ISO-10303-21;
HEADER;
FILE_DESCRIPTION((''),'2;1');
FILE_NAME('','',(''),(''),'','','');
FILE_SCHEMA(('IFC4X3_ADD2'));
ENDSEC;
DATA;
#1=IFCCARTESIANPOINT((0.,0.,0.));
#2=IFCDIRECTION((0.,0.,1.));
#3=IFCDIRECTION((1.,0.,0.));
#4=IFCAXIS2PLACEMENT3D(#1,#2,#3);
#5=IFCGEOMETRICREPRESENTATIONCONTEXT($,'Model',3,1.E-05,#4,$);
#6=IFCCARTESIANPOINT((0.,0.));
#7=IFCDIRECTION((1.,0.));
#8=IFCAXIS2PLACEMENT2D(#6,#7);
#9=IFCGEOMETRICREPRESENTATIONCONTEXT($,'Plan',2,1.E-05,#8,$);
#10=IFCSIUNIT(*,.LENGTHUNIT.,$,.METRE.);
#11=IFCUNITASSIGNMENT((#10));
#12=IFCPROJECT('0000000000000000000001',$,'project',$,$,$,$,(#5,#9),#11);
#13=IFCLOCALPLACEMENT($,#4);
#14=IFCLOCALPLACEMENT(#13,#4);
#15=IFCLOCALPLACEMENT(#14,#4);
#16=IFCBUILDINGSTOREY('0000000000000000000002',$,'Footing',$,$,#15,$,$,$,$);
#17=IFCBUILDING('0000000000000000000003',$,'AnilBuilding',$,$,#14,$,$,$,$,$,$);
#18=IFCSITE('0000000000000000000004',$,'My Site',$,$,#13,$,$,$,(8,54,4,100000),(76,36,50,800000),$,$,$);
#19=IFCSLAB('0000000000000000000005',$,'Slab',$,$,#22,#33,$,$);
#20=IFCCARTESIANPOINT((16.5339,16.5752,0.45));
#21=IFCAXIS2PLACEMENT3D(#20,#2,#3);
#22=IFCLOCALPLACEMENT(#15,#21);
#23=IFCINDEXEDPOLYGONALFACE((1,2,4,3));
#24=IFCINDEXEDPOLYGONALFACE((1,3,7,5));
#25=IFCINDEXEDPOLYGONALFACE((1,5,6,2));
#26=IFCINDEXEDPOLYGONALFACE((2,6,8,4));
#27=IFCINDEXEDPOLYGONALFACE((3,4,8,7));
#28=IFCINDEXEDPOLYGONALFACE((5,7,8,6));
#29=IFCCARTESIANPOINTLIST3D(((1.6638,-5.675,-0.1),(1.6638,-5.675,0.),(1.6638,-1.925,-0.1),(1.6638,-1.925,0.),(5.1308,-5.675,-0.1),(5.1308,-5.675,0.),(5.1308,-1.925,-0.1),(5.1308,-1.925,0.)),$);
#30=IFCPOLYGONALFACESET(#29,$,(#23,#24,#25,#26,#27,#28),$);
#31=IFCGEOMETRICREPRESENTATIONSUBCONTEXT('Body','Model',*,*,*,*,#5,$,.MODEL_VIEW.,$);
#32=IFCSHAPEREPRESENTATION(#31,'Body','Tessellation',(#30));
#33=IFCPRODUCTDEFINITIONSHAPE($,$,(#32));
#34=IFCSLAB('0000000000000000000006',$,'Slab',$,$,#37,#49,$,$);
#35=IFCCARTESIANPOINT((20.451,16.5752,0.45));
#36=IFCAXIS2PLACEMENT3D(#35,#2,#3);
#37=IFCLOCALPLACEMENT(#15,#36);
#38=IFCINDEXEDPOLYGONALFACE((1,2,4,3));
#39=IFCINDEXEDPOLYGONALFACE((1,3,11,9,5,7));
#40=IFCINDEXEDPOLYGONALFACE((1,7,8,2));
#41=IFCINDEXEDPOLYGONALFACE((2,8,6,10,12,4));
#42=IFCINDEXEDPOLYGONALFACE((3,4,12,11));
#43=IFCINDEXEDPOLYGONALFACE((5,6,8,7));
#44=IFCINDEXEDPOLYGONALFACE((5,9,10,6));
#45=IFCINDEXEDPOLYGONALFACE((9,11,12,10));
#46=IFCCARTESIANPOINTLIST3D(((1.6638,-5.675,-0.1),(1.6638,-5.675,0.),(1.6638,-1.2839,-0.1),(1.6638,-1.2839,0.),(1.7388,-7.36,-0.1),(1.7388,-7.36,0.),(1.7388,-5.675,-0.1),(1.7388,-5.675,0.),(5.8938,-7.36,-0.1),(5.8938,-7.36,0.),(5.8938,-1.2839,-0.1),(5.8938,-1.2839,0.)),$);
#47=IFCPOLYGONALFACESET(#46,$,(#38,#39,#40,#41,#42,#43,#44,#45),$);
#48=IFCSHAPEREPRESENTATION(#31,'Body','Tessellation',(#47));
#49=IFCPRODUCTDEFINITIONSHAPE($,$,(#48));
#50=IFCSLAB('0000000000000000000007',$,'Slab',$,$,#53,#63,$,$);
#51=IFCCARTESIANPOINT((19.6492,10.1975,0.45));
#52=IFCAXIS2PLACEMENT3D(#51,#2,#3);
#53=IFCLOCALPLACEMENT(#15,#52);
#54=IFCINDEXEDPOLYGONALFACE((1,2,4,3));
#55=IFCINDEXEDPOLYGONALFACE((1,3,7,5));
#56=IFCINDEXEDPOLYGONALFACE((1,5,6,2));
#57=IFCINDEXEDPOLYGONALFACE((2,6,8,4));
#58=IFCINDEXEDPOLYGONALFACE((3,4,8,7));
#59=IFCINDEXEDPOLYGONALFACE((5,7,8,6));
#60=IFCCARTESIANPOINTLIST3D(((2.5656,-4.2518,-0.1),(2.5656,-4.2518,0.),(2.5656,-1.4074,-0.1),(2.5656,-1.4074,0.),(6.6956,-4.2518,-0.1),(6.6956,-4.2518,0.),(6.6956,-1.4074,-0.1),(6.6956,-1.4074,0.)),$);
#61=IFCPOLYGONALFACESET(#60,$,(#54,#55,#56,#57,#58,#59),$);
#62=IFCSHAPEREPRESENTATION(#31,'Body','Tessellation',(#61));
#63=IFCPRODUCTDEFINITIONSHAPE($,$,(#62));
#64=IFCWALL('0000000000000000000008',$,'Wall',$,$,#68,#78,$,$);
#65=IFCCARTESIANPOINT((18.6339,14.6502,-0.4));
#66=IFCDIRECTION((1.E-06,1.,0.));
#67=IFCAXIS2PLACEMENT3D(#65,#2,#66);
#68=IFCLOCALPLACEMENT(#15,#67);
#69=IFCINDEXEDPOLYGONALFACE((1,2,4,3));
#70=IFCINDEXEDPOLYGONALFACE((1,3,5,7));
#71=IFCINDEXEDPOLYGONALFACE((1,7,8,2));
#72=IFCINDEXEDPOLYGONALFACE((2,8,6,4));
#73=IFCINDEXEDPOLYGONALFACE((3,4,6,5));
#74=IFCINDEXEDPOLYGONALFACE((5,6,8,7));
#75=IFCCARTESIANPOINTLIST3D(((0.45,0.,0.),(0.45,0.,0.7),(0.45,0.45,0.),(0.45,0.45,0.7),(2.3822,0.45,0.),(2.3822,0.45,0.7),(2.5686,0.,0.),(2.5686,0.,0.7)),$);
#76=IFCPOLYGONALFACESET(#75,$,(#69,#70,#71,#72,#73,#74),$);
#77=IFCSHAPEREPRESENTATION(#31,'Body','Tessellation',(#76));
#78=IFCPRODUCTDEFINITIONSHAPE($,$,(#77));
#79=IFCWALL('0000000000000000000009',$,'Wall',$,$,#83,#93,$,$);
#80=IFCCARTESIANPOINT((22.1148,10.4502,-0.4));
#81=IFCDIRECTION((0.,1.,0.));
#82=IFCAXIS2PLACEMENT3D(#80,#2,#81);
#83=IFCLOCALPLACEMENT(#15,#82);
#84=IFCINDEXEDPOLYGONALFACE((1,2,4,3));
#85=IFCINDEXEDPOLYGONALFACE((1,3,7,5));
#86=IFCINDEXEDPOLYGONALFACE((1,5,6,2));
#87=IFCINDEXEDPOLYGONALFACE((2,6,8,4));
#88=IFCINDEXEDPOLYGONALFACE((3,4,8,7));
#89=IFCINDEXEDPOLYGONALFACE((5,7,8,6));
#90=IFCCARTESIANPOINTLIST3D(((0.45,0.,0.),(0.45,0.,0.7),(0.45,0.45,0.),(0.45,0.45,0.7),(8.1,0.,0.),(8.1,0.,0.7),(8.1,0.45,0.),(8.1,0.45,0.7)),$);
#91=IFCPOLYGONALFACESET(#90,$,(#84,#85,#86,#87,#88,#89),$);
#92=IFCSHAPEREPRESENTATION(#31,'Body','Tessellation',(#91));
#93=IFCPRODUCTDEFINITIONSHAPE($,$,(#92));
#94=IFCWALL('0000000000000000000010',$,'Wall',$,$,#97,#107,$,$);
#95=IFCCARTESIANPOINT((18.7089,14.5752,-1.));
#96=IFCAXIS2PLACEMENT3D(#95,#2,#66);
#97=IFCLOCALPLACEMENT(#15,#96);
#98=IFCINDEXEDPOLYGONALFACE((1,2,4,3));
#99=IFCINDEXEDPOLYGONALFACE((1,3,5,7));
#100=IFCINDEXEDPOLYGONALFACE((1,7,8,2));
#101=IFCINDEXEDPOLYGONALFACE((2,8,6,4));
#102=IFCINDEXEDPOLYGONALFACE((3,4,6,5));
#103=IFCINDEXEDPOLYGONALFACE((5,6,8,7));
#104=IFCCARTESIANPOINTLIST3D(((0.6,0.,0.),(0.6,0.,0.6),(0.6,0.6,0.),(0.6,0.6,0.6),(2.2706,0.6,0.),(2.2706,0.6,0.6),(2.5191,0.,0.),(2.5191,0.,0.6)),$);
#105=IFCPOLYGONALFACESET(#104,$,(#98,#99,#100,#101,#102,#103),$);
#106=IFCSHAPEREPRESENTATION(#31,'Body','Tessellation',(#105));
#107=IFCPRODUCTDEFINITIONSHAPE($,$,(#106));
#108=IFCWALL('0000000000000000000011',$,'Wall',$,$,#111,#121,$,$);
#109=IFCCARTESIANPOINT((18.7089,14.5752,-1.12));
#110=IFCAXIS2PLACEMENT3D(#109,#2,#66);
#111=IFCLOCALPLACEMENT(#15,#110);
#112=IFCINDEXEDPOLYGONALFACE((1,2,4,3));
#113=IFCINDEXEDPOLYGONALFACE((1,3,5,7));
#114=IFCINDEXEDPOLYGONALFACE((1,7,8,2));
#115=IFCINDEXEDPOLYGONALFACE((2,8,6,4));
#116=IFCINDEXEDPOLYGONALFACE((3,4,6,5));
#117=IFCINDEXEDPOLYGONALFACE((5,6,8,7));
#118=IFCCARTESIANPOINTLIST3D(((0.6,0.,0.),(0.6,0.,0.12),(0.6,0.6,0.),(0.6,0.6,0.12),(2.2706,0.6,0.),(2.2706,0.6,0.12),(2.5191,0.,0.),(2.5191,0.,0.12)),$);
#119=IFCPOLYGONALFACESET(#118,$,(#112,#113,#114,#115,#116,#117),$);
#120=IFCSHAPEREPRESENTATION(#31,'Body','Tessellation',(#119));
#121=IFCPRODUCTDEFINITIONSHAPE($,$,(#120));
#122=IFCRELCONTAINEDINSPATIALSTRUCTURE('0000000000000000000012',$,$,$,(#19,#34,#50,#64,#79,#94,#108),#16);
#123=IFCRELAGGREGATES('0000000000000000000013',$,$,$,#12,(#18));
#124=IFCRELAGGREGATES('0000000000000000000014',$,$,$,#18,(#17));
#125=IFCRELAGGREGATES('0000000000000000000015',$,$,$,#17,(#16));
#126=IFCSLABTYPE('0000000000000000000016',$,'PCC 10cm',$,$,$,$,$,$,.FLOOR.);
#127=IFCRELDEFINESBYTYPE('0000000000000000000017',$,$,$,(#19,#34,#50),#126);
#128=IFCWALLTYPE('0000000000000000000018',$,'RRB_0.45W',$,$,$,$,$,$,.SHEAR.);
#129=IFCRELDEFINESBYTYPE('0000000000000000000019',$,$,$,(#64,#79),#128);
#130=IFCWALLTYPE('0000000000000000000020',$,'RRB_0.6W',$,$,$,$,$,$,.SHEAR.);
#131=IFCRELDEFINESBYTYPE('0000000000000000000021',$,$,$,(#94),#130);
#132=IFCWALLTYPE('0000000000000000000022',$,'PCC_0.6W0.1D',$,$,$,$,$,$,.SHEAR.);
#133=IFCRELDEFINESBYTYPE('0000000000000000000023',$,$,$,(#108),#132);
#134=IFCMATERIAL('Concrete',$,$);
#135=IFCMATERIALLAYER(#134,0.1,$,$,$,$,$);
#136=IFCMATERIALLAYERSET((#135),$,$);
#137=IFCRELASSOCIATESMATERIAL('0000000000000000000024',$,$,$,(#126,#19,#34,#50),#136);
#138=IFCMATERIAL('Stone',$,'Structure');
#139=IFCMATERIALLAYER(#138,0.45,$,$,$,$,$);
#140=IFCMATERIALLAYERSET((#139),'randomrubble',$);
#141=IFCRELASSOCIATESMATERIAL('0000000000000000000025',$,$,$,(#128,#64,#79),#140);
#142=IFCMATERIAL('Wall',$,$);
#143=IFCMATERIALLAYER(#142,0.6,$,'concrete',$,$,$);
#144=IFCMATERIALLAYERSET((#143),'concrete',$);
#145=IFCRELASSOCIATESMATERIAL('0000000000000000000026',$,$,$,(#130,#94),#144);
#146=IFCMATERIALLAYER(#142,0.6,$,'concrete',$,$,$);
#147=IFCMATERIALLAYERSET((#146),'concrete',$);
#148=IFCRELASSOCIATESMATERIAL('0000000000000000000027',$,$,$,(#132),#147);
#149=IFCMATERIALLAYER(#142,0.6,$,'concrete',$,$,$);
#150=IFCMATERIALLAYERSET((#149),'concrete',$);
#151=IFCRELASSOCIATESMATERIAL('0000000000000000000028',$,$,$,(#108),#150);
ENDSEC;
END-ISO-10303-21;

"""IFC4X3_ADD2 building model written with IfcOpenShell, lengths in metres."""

from ifc_helpers import new_model, si_unit, frame, origin_with_axes, origin_2d_with_axis, place, context, subcontext, project, spatial, line, indexed_curve, outline, extrude, material, layer, layer_set, layer_usage, type_object, element, save


model = new_model("IFC4X3_ADD2")

# Units and contexts
model_context = context("Model", 3, precision=1e-05, world=origin_with_axes())
plan_context = context("Plan", 2, precision=1e-05, world=origin_2d_with_axis())
body_context = subcontext(model_context, "Body", "Model", "MODEL_VIEW")
ifc_project = project(units=[si_unit("LENGTHUNIT", "METRE")], contexts=[model_context, plan_context])

# Site, building, storey
site_placement = place(None, origin_with_axes())
site = spatial("IfcSite", under=ifc_project, at=site_placement, Name="My Site", RefLatitude=(8, 54, 4, 100000), RefLongitude=(76, 36, 50, 800000))
building_placement = place(site_placement, origin_with_axes())
building = spatial("IfcBuilding", under=site, at=building_placement, Name="AnilBuilding")
storey_placement = place(building_placement, origin_with_axes())
storey = spatial("IfcBuildingStorey", under=building, at=storey_placement, Name="Footing")

# Shared definitions
ifc_material_1 = material(Name="Stone", Category="Structure")
ifc_material_2 = material(Name="Concrete")

# Slabs
ifc_layer_1 = layer(ifc_material_2, 0.1)
ifc_layer_set_1 = layer_set([ifc_layer_1])
ifc_layer_usage_1 = layer_usage(ifc_layer_set_1, "AXIS3", "POSITIVE", -0.1)
slab_type = type_object("IfcSlabType", Name="PCC 10cm", PredefinedType="FLOOR", material=ifc_layer_set_1)
slab_1_placement = place(storey_placement, frame((16.5339, 16.5752, 0.45), z_axis=(0.0, 0.0, 1.0), x_axis=(1.0, 0.0, 0.0)))
element("IfcSlab", 1, at=slab_1_placement, inside=storey, type_object=slab_type, material=ifc_layer_usage_1, Name="Slab", context=body_context, shape_type="SweptSolid", body=[
    extrude(outline(indexed_curve([(1.6638, -1.925), (5.1308, -1.925), (5.1308, -5.675), (1.6638, -5.675), (1.6638, -1.925)])), frame((0.0, 0.0, -0.1), z_axis=(0.0, 0.0, 1.0), x_axis=(1.0, 0.0, 0.0)), (0.0, 0.0, 1.0), 0.1),
])
ifc_layer_usage_2 = layer_usage(ifc_layer_set_1, "AXIS3", "POSITIVE", -0.1)
slab_2_placement = place(storey_placement, frame((20.451, 16.5752, 0.45), z_axis=(0.0, 0.0, 1.0), x_axis=(1.0, 0.0, 0.0)))
element("IfcSlab", 2, at=slab_2_placement, inside=storey, type_object=slab_type, material=ifc_layer_usage_2, Name="Slab", context=body_context, shape_type="SweptSolid", body=[
    extrude(outline(indexed_curve([(5.8938, -7.36), (5.8938, -1.2839), (1.6638, -1.2839), (1.6638, -5.675), (1.7388, -5.675), (1.7388, -7.36), (5.8938, -7.36)])), frame((0.0, 0.0, -0.1), z_axis=(0.0, 0.0, 1.0), x_axis=(1.0, 0.0, 0.0)), (0.0, 0.0, 1.0), 0.1),
])
ifc_layer_usage_3 = layer_usage(ifc_layer_set_1, "AXIS3", "POSITIVE", -0.1)
slab_3_placement = place(storey_placement, frame((19.6492, 10.1975, 0.45), z_axis=(0.0, 0.0, 1.0), x_axis=(1.0, 0.0, 0.0)))
element("IfcSlab", 3, at=slab_3_placement, inside=storey, type_object=slab_type, material=ifc_layer_usage_3, Name="Slab", context=body_context, shape_type="SweptSolid", body=[
    extrude(outline(indexed_curve([(2.5656, -1.4074), (6.6956, -1.4074), (6.6956, -4.2518), (2.5656, -4.2518), (2.5656, -1.4074)])), frame((0.0, 0.0, -0.1), z_axis=(0.0, 0.0, 1.0), x_axis=(1.0, 0.0, 0.0)), (0.0, 0.0, 1.0), 0.1),
])

# Walls
ifc_layer_2 = layer(ifc_material_1, 0.45)
ifc_layer_set_2 = layer_set([ifc_layer_2], Name="randomrubble")
wall_type_1 = type_object("IfcWallType", Name="RRB_0.45W", PredefinedType="SHEAR", material=ifc_layer_set_2)
ifc_layer_usage_4 = layer_usage(ifc_layer_set_2, "AXIS2", "POSITIVE", 0.0)
wall_1_placement = place(storey_placement, frame((18.6339, 14.6502, -0.4), z_axis=(0.0, 0.0, 1.0), x_axis=(0.000001, 1.0, 0.0)))
element("IfcWall", 4, at=wall_1_placement, inside=storey, type_object=wall_type_1, material=ifc_layer_usage_4, Name="Wall", context=body_context, shape_type="SweptSolid", body=[
    extrude(outline(indexed_curve([(0.45, 0.0), (0.45, 0.45), (2.3822, 0.45), (2.5686, 0.0)], segments=[line(1, 2, 3, 4, 1)])), origin_with_axes(), (0.0, 0.0, 1.0), 0.7),
])
ifc_layer_usage_5 = layer_usage(ifc_layer_set_2, "AXIS2", "POSITIVE", 0.0)
wall_2_placement = place(storey_placement, frame((22.1148, 10.4502, -0.4), z_axis=(0.0, 0.0, 1.0), x_axis=(0.0, 1.0, 0.0)))
element("IfcWall", 5, at=wall_2_placement, inside=storey, type_object=wall_type_1, material=ifc_layer_usage_5, Name="Wall", context=body_context, shape_type="SweptSolid", body=[
    extrude(outline(indexed_curve([(0.45, 0.0), (0.45, 0.45), (8.1, 0.45), (8.1, 0.0)], segments=[line(1, 2, 3, 4, 1)])), origin_with_axes(), (0.0, 0.0, 1.0), 0.7),
])
ifc_material_3 = material(Name="Wall")
ifc_layer_3 = layer(ifc_material_3, 0.6, Name="concrete")
ifc_layer_set_3 = layer_set([ifc_layer_3], Name="concrete")
wall_type_2 = type_object("IfcWallType", Name="RRB_0.6W", PredefinedType="SHEAR", material=ifc_layer_set_3)
ifc_layer_usage_6 = layer_usage(ifc_layer_set_3, "AXIS2", "POSITIVE", 0.0)
wall_3_placement = place(storey_placement, frame((18.7089, 14.5752, -1.0), z_axis=(0.0, 0.0, 1.0), x_axis=(0.000001, 1.0, 0.0)))
element("IfcWall", 6, at=wall_3_placement, inside=storey, type_object=wall_type_2, material=ifc_layer_usage_6, Name="Wall", context=body_context, shape_type="SweptSolid", body=[
    extrude(outline(indexed_curve([(0.6, 0.0), (0.6, 0.6), (2.2706, 0.6), (2.5191, 0.0)], segments=[line(1, 2, 3, 4, 1)])), origin_with_axes(), (0.0, 0.0, 1.0), 0.6),
])
ifc_layer_4 = layer(ifc_material_3, 0.6, Name="concrete")
ifc_layer_set_4 = layer_set([ifc_layer_4], Name="concrete")
wall_type_3 = type_object("IfcWallType", Name="PCC_0.6W0.1D", PredefinedType="SHEAR", material=ifc_layer_set_4)
ifc_layer_5 = layer(ifc_material_3, 0.6, Name="concrete")
ifc_layer_set_5 = layer_set([ifc_layer_5], Name="concrete")
ifc_layer_usage_7 = layer_usage(ifc_layer_set_5, "AXIS2", "POSITIVE", 0.0)
wall_4_placement = place(storey_placement, frame((18.7089, 14.5752, -1.12), z_axis=(0.0, 0.0, 1.0), x_axis=(0.000001, 1.0, 0.0)))
element("IfcWall", 7, at=wall_4_placement, inside=storey, type_object=wall_type_3, material=ifc_layer_usage_7, Name="Wall", context=body_context, shape_type="SweptSolid", body=[
    extrude(outline(indexed_curve([(0.6, 0.0), (0.6, 0.6), (2.2706, 0.6), (2.5191, 0.0)], segments=[line(1, 2, 3, 4, 1)])), origin_with_axes(), (0.0, 0.0, 1.0), 0.12),
])

save(model, "model.ifc")
